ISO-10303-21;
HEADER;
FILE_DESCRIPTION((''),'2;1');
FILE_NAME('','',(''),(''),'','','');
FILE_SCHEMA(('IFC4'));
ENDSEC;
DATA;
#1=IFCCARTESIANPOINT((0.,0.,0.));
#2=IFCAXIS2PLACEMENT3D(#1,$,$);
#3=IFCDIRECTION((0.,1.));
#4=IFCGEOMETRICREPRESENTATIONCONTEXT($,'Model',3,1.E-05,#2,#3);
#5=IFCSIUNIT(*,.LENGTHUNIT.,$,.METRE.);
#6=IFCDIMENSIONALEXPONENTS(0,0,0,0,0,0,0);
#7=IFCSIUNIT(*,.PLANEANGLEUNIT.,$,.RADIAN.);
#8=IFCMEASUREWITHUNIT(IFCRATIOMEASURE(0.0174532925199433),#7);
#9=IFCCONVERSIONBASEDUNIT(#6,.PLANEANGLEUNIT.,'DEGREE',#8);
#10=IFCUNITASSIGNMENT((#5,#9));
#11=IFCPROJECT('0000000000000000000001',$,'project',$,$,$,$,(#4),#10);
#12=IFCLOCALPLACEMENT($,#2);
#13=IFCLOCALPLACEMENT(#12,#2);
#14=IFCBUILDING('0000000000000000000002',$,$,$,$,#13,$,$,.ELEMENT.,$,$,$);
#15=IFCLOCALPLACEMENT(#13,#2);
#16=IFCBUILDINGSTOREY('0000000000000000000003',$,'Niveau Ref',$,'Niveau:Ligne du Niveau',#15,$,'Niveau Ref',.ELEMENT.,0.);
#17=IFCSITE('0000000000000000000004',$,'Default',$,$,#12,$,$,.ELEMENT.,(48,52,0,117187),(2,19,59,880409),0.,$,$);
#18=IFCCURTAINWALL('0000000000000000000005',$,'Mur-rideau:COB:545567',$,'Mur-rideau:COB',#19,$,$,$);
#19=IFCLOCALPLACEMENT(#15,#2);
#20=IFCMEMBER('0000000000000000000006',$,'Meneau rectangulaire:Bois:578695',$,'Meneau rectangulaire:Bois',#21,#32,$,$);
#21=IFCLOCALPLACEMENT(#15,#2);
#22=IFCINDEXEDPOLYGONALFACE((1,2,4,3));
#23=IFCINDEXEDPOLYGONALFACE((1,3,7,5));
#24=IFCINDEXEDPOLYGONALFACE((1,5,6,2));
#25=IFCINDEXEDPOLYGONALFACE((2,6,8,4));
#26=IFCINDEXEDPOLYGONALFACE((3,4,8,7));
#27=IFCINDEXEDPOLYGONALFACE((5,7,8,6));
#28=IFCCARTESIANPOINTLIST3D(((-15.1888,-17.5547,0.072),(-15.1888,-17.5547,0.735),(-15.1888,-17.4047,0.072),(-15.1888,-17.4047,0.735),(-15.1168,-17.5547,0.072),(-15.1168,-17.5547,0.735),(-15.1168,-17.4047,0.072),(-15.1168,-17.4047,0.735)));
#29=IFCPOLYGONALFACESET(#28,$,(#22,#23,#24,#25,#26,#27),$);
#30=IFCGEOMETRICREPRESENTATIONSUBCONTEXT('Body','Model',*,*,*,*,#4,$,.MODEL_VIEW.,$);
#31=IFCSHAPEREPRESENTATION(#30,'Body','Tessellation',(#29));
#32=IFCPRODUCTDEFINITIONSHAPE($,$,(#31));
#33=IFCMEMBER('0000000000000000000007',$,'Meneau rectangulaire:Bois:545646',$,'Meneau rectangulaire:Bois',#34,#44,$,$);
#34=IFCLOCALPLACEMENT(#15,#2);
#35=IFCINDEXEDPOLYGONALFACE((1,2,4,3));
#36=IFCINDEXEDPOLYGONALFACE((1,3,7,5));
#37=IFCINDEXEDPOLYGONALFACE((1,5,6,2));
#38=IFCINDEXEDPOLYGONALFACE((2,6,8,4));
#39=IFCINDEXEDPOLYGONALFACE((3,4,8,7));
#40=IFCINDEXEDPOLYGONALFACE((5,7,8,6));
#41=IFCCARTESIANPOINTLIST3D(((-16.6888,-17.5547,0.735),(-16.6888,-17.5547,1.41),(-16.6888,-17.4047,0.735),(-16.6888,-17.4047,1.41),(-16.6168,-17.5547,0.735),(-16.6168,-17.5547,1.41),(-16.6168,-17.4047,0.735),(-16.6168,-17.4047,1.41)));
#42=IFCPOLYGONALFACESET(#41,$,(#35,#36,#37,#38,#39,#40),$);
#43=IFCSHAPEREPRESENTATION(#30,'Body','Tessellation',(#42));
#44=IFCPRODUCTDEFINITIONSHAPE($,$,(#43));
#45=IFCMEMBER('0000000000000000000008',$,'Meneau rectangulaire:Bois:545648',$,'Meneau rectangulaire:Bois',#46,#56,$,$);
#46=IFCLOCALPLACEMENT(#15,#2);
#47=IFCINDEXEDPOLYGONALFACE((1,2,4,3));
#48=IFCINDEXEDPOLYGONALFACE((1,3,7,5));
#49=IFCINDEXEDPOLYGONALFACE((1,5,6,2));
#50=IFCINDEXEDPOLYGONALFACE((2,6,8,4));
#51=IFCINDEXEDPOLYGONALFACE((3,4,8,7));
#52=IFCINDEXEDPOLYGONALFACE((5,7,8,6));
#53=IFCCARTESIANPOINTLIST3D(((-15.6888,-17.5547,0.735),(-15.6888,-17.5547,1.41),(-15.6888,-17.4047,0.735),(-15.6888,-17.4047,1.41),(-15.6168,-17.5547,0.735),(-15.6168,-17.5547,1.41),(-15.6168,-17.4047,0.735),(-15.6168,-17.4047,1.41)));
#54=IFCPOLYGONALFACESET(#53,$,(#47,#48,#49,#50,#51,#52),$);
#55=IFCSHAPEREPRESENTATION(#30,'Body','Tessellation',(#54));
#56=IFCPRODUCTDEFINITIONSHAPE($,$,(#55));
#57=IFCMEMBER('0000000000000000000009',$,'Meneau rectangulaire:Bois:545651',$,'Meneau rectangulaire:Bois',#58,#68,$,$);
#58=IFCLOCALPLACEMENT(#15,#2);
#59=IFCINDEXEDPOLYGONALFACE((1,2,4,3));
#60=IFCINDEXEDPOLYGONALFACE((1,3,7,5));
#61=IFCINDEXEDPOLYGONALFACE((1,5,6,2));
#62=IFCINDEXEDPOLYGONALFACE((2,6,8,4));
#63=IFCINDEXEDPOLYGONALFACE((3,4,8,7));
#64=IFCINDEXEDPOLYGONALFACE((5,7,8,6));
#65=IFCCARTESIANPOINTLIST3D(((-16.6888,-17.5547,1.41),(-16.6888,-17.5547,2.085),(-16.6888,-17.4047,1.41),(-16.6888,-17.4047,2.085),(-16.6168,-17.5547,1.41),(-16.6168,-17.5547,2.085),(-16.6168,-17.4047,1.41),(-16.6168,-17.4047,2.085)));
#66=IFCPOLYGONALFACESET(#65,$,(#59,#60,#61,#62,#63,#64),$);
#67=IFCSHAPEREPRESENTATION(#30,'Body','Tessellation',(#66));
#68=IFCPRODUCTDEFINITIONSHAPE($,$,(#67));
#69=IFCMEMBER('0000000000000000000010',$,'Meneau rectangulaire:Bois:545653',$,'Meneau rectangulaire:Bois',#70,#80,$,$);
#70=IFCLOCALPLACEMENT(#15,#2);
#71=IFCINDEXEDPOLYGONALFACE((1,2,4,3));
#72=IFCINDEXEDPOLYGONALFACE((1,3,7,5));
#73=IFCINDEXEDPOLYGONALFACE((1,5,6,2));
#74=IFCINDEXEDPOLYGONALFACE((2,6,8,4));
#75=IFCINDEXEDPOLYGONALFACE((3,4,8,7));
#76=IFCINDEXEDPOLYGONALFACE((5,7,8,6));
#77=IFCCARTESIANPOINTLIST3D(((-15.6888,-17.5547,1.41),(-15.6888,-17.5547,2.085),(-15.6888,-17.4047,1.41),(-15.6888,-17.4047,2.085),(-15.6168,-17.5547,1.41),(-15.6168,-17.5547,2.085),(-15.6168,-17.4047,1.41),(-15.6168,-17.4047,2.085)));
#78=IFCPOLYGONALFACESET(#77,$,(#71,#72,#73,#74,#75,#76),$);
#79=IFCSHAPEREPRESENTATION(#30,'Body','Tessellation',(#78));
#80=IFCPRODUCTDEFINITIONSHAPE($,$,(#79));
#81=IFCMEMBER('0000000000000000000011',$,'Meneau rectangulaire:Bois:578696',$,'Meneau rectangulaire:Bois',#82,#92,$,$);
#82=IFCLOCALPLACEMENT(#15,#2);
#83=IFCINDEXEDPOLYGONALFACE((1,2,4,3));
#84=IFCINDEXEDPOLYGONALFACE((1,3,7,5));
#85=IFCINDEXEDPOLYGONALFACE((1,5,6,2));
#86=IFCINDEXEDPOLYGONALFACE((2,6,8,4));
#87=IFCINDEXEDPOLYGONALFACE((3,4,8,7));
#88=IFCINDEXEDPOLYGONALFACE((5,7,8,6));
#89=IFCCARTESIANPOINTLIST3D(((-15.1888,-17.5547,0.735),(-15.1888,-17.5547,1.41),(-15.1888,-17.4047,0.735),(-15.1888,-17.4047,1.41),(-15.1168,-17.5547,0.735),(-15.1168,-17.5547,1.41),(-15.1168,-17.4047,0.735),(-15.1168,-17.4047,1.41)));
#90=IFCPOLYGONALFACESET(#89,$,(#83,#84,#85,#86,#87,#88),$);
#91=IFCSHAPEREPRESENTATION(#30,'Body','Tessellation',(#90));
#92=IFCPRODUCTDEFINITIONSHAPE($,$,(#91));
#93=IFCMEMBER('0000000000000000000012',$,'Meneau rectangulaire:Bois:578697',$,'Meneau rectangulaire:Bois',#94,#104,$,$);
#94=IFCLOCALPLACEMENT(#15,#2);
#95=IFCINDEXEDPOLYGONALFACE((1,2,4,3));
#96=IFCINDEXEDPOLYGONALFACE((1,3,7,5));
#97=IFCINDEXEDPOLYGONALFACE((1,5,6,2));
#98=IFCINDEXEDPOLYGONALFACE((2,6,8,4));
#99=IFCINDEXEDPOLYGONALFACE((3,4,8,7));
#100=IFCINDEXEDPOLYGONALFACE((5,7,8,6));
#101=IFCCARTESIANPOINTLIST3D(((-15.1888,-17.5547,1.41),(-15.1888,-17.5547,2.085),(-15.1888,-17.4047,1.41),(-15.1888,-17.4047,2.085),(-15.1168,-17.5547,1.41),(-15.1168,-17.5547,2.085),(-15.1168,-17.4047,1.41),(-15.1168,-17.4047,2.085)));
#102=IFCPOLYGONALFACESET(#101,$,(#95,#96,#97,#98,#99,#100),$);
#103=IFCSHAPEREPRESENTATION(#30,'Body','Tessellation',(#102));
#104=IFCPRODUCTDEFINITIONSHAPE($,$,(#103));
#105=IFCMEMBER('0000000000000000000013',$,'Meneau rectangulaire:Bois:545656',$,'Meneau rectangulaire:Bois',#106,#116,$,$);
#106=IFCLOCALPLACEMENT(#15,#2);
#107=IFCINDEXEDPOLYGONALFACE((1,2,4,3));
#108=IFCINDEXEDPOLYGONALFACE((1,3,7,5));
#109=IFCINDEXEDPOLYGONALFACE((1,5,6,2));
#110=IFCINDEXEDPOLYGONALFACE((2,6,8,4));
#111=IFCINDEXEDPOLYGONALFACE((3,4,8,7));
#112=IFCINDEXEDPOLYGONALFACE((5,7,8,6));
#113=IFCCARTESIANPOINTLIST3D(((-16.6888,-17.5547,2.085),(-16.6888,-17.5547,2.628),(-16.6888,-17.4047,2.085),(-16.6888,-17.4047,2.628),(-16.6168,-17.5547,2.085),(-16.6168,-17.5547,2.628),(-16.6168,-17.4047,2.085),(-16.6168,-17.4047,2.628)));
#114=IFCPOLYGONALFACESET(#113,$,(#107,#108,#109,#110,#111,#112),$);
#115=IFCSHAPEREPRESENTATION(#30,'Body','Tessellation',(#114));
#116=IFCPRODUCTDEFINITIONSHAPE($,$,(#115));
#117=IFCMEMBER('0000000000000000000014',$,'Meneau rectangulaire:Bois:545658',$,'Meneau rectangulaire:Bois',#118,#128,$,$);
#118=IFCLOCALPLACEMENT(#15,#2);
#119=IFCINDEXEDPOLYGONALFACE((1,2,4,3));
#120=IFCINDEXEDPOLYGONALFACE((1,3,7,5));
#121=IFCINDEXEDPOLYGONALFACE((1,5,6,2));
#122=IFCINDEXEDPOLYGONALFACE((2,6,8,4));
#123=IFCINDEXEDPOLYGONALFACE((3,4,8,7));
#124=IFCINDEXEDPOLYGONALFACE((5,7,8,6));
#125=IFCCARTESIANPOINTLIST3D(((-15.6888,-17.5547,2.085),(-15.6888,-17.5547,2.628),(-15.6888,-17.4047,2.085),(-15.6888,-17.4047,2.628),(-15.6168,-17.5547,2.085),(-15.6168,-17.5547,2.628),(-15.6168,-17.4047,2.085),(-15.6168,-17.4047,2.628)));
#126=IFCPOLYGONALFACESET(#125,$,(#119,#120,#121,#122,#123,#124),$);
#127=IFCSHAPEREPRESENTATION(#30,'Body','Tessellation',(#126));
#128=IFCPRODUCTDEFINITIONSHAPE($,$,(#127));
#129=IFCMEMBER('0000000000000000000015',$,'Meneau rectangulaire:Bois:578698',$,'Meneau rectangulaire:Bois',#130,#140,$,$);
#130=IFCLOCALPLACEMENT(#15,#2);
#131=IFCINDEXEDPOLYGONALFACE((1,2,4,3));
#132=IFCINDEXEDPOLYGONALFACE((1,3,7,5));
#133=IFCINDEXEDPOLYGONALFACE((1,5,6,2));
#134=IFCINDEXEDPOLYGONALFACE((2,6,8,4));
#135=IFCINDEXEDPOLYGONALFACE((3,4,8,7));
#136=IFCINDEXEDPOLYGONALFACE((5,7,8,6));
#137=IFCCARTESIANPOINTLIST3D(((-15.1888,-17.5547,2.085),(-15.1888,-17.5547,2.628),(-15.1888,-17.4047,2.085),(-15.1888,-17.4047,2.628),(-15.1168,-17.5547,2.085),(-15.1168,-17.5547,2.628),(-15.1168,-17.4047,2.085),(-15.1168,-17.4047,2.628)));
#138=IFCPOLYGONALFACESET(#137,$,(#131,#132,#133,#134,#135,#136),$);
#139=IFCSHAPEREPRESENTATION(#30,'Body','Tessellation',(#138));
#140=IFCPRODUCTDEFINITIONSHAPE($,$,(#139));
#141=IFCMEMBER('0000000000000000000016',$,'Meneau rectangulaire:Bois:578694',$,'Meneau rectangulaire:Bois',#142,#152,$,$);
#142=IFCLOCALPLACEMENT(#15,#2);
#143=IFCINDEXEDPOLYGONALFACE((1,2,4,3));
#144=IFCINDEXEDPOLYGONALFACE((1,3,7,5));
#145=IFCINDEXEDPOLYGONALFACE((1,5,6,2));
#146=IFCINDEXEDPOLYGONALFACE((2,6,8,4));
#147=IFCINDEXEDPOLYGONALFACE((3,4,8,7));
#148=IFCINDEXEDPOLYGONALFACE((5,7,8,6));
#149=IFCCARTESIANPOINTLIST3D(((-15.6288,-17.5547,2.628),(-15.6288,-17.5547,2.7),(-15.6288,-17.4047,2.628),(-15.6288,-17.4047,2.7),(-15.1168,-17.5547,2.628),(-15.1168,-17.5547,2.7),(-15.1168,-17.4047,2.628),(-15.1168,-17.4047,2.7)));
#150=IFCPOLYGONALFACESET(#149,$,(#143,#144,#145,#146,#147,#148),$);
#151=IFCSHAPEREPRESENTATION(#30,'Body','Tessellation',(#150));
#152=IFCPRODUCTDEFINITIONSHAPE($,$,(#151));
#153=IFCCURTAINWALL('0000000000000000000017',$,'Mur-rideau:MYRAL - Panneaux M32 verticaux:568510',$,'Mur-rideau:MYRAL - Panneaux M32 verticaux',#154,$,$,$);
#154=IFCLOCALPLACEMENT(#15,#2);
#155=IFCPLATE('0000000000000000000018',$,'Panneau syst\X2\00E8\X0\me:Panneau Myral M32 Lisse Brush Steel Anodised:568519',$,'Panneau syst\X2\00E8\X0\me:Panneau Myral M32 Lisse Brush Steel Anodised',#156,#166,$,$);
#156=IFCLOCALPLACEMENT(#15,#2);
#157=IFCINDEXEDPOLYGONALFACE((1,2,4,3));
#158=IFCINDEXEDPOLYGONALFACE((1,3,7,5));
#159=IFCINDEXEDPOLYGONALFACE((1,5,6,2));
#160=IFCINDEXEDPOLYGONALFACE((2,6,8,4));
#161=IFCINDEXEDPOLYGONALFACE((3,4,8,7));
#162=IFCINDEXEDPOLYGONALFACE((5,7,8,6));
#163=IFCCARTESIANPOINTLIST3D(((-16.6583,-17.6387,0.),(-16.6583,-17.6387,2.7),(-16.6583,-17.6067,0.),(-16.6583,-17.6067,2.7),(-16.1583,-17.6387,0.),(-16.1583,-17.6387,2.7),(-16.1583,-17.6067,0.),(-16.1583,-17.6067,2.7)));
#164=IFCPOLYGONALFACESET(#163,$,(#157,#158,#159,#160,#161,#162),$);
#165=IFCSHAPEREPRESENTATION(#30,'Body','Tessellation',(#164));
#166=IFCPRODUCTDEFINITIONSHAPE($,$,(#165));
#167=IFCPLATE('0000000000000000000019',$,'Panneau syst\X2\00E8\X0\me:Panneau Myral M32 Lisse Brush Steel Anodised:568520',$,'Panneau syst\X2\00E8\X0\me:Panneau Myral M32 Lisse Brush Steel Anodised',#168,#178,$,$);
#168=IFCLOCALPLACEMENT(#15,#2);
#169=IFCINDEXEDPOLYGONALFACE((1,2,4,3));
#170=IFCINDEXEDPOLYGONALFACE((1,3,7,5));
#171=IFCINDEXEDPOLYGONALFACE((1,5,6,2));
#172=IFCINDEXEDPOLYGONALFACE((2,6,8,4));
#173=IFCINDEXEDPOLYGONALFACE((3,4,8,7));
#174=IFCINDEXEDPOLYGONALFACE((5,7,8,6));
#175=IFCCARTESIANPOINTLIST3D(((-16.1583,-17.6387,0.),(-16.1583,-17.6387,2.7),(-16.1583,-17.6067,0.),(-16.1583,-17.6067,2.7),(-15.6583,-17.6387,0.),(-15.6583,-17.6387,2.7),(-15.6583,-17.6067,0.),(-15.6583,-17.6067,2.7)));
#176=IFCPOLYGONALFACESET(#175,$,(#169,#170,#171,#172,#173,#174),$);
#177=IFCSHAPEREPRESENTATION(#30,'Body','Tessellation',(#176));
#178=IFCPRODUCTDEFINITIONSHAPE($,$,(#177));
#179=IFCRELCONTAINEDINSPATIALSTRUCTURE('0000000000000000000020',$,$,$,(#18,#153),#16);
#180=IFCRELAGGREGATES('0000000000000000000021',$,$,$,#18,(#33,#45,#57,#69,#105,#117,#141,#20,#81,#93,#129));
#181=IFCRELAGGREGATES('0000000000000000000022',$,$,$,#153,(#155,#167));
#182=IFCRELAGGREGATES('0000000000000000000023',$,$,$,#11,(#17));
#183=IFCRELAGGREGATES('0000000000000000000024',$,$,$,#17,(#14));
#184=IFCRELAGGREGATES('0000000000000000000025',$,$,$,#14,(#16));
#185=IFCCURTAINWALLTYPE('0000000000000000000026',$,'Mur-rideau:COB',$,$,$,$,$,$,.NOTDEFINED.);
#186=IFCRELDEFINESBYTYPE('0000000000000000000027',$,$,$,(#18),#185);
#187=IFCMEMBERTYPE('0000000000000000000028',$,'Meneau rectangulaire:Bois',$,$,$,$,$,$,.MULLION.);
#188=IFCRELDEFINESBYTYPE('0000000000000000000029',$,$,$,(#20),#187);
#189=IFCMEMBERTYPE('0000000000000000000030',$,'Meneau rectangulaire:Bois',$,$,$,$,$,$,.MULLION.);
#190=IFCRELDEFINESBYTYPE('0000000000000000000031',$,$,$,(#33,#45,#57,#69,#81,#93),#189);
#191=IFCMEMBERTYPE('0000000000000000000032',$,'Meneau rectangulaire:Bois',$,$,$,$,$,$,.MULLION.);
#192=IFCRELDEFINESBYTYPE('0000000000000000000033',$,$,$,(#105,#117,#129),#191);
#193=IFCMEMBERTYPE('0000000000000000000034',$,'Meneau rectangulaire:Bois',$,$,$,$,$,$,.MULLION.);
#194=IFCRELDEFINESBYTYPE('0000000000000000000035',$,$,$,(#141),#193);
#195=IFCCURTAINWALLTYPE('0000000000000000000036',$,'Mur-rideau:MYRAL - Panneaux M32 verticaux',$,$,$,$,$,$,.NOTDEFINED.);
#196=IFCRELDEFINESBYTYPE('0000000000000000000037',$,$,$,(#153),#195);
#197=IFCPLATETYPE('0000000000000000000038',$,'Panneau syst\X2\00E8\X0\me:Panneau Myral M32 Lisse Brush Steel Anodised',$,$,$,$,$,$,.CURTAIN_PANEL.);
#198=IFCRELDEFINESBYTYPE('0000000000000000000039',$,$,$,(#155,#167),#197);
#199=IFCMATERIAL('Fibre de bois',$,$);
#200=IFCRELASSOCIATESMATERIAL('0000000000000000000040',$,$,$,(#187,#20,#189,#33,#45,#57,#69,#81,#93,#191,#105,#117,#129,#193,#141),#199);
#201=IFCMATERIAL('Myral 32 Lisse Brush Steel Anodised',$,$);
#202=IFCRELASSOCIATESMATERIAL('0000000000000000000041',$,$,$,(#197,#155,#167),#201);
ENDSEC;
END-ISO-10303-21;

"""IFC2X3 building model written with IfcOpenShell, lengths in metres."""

from ifc_helpers import new_model, entity, si_unit, converted_unit, direction, frame, origin, origin_2d_with_axis, place, context, subcontext, project, spatial, rectangle, extrude, source, transform, mapped, material, type_object, type_shapes, element, aggregate, save


model = new_model("IFC2X3")

# Units and contexts
model_context = context("Model", 3, precision=1e-05, world=origin(), true_north=direction((0.0, 1.0)))
body_context = subcontext(model_context, "Body", "Model", "MODEL_VIEW")
ifc_project = project(units=[si_unit("LENGTHUNIT", "METRE"), converted_unit("PLANEANGLEUNIT", "DEGREE", entity("IfcRatioMeasure", 0.0174532925199433), si_unit("PLANEANGLEUNIT", "RADIAN"), dimensions=[0, 0, 0, 0, 0, 0, 0])], contexts=[model_context])

# Site, building, storey
site_placement = place(None, origin())
site = spatial("IfcSite", under=ifc_project, at=site_placement, Name="Default", CompositionType="ELEMENT", RefLatitude=(48, 52, 0, 117187), RefLongitude=(2, 19, 59, 880409), RefElevation=0.0)
building_placement = place(site_placement, origin())
building = spatial("IfcBuilding", under=site, at=building_placement, CompositionType="ELEMENT")
storey_placement = place(building_placement, origin())
storey = spatial("IfcBuildingStorey", under=building, at=storey_placement, Name="Niveau Ref", ObjectType="Niveau:Ligne du Niveau", LongName="Niveau Ref", CompositionType="ELEMENT", Elevation=0.0)

# Curtain wall, members
curtain_wall_type_1 = type_object("IfcCurtainWallType", Name="Mur-rideau:COB", PredefinedType="NOTDEFINED")
curtain_wall_1_placement = place(storey_placement, origin())
curtain_wall_1 = element("IfcCurtainWall", 1, at=curtain_wall_1_placement, inside=storey, type_object=curtain_wall_type_1, Name="Mur-rideau:COB:545567", ObjectType="Mur-rideau:COB")
ifc_material_1 = material(Name="Fibre de bois")
member_type_1 = type_object("IfcMemberType", Name="Meneau rectangulaire:Bois", PredefinedType="MULLION", material=ifc_material_1)
shared_shape_1 = source(origin(), body_context, "Body", "SweptSolid", [
    extrude(rectangle(XDim=0.15, YDim=0.072, at=origin_2d_with_axis()), frame((-0.024, 0.0, -0.663), z_axis=(0.0, 0.0, 1.0), x_axis=(0.0, -1.0, 0.0)), (0.0, 0.0, 1.0), 0.663),
])
type_shapes(member_type_1, [shared_shape_1])
member_1_placement = place(storey_placement, frame((-15.1288, -17.4797, 0.072), z_axis=(0.0, 0.0, -1.0), x_axis=(1.0, 0.0, 0.0)))
member_1 = element("IfcMember", 2, at=member_1_placement, type_object=member_type_1, material=ifc_material_1, Name="Meneau rectangulaire:Bois:578695", ObjectType="Meneau rectangulaire:Bois", context=body_context, shape_type="MappedRepresentation", body=[
    mapped(shared_shape_1, transform((0.0, 0.0, 0.0), scale=1.0)),
])
member_type_2 = type_object("IfcMemberType", Name="Meneau rectangulaire:Bois", PredefinedType="MULLION", material=ifc_material_1)
shared_shape_2 = source(origin(), body_context, "Body", "SweptSolid", [
    extrude(rectangle(XDim=0.15, YDim=0.072, at=origin_2d_with_axis()), frame((-0.024, 0.0, -0.675), z_axis=(0.0, 0.0, 1.0), x_axis=(0.0, -1.0, 0.0)), (0.0, 0.0, 1.0), 0.675),
])
type_shapes(member_type_2, [shared_shape_2])
member_2_placement = place(storey_placement, frame((-16.6288, -17.4797, 0.735), z_axis=(0.0, 0.0, -1.0), x_axis=(1.0, 0.0, 0.0)))
member_2 = element("IfcMember", 3, at=member_2_placement, type_object=member_type_2, material=ifc_material_1, Name="Meneau rectangulaire:Bois:545646", ObjectType="Meneau rectangulaire:Bois", context=body_context, shape_type="MappedRepresentation", body=[
    mapped(shared_shape_2, transform((0.0, 0.0, 0.0), scale=1.0)),
])
member_3_placement = place(storey_placement, frame((-15.6288, -17.4797, 0.735), z_axis=(0.0, 0.0, -1.0), x_axis=(1.0, 0.0, 0.0)))
member_3 = element("IfcMember", 4, at=member_3_placement, type_object=member_type_2, material=ifc_material_1, Name="Meneau rectangulaire:Bois:545648", ObjectType="Meneau rectangulaire:Bois", context=body_context, shape_type="MappedRepresentation", body=[
    mapped(shared_shape_2, transform((0.0, 0.0, 0.0), scale=1.0)),
])
member_4_placement = place(storey_placement, frame((-16.6288, -17.4797, 1.41), z_axis=(0.0, 0.0, -1.0), x_axis=(1.0, 0.0, 0.0)))
member_4 = element("IfcMember", 5, at=member_4_placement, type_object=member_type_2, material=ifc_material_1, Name="Meneau rectangulaire:Bois:545651", ObjectType="Meneau rectangulaire:Bois", context=body_context, shape_type="MappedRepresentation", body=[
    mapped(shared_shape_2, transform((0.0, 0.0, 0.0), scale=1.0)),
])
member_5_placement = place(storey_placement, frame((-15.6288, -17.4797, 1.41), z_axis=(0.0, 0.0, -1.0), x_axis=(1.0, 0.0, 0.0)))
member_5 = element("IfcMember", 6, at=member_5_placement, type_object=member_type_2, material=ifc_material_1, Name="Meneau rectangulaire:Bois:545653", ObjectType="Meneau rectangulaire:Bois", context=body_context, shape_type="MappedRepresentation", body=[
    mapped(shared_shape_2, transform((0.0, 0.0, 0.0), scale=1.0)),
])
member_6_placement = place(storey_placement, frame((-15.1288, -17.4797, 0.735), z_axis=(0.0, 0.0, -1.0), x_axis=(1.0, 0.0, 0.0)))
member_6 = element("IfcMember", 7, at=member_6_placement, type_object=member_type_2, material=ifc_material_1, Name="Meneau rectangulaire:Bois:578696", ObjectType="Meneau rectangulaire:Bois", context=body_context, shape_type="MappedRepresentation", body=[
    mapped(shared_shape_2, transform((0.0, 0.0, 0.0), scale=1.0)),
])
member_7_placement = place(storey_placement, frame((-15.1288, -17.4797, 1.41), z_axis=(0.0, 0.0, -1.0), x_axis=(1.0, 0.0, 0.0)))
member_7 = element("IfcMember", 8, at=member_7_placement, type_object=member_type_2, material=ifc_material_1, Name="Meneau rectangulaire:Bois:578697", ObjectType="Meneau rectangulaire:Bois", context=body_context, shape_type="MappedRepresentation", body=[
    mapped(shared_shape_2, transform((0.0, 0.0, 0.0), scale=1.0)),
])
member_type_3 = type_object("IfcMemberType", Name="Meneau rectangulaire:Bois", PredefinedType="MULLION", material=ifc_material_1)
shared_shape_3 = source(origin(), body_context, "Body", "SweptSolid", [
    extrude(rectangle(XDim=0.15, YDim=0.072, at=origin_2d_with_axis()), frame((-0.024, 0.0, -0.543), z_axis=(0.0, 0.0, 1.0), x_axis=(0.0, -1.0, 0.0)), (0.0, 0.0, 1.0), 0.543),
])
type_shapes(member_type_3, [shared_shape_3])
member_8_placement = place(storey_placement, frame((-16.6288, -17.4797, 2.085), z_axis=(0.0, 0.0, -1.0), x_axis=(1.0, 0.0, 0.0)))
member_8 = element("IfcMember", 9, at=member_8_placement, type_object=member_type_3, material=ifc_material_1, Name="Meneau rectangulaire:Bois:545656", ObjectType="Meneau rectangulaire:Bois", context=body_context, shape_type="MappedRepresentation", body=[
    mapped(shared_shape_3, transform((0.0, 0.0, 0.0), scale=1.0)),
])
member_9_placement = place(storey_placement, frame((-15.6288, -17.4797, 2.085), z_axis=(0.0, 0.0, -1.0), x_axis=(1.0, 0.0, 0.0)))
member_9 = element("IfcMember", 10, at=member_9_placement, type_object=member_type_3, material=ifc_material_1, Name="Meneau rectangulaire:Bois:545658", ObjectType="Meneau rectangulaire:Bois", context=body_context, shape_type="MappedRepresentation", body=[
    mapped(shared_shape_3, transform((0.0, 0.0, 0.0), scale=1.0)),
])
member_10_placement = place(storey_placement, frame((-15.1288, -17.4797, 2.085), z_axis=(0.0, 0.0, -1.0), x_axis=(1.0, 0.0, 0.0)))
member_10 = element("IfcMember", 11, at=member_10_placement, type_object=member_type_3, material=ifc_material_1, Name="Meneau rectangulaire:Bois:578698", ObjectType="Meneau rectangulaire:Bois", context=body_context, shape_type="MappedRepresentation", body=[
    mapped(shared_shape_3, transform((0.0, 0.0, 0.0), scale=1.0)),
])
member_type_4 = type_object("IfcMemberType", Name="Meneau rectangulaire:Bois", PredefinedType="MULLION", material=ifc_material_1)
shared_shape_4 = source(origin(), body_context, "Body", "SweptSolid", [
    extrude(rectangle(XDim=0.15, YDim=0.072, at=origin_2d_with_axis()), frame((-0.036, 0.0, -0.512), z_axis=(0.0, 0.0, 1.0), x_axis=(0.0, -1.0, 0.0)), (0.0, 0.0, 1.0), 0.512),
])
type_shapes(member_type_4, [shared_shape_4])
member_11_placement = place(storey_placement, frame((-15.1168, -17.4797, 2.7), z_axis=(1.0, 0.0, 0.0), x_axis=(0.0, 0.0, 1.0)))
member_11 = element("IfcMember", 12, at=member_11_placement, type_object=member_type_4, material=ifc_material_1, Name="Meneau rectangulaire:Bois:578694", ObjectType="Meneau rectangulaire:Bois", context=body_context, shape_type="MappedRepresentation", body=[
    mapped(shared_shape_4, transform((0.0, 0.0, 0.0), scale=1.0)),
])
aggregate(curtain_wall_1, [member_2, member_3, member_4, member_5, member_8, member_9, member_11, member_1, member_6, member_7, member_10])

# Curtain wall, plates
curtain_wall_type_2 = type_object("IfcCurtainWallType", Name="Mur-rideau:MYRAL - Panneaux M32 verticaux", PredefinedType="NOTDEFINED")
curtain_wall_2_placement = place(storey_placement, origin())
curtain_wall_2 = element("IfcCurtainWall", 13, at=curtain_wall_2_placement, inside=storey, type_object=curtain_wall_type_2, Name="Mur-rideau:MYRAL - Panneaux M32 verticaux:568510", ObjectType="Mur-rideau:MYRAL - Panneaux M32 verticaux")
ifc_material_2 = material(Name="Myral 32 Lisse Brush Steel Anodised")
plate_type = type_object("IfcPlateType", Name="Panneau système:Panneau Myral M32 Lisse Brush Steel Anodised", PredefinedType="CURTAIN_PANEL", material=ifc_material_2)
shared_shape_5 = source(origin(), body_context, "Body", "SweptSolid", [
    extrude(rectangle(XDim=0.032, YDim=0.5, at=origin_2d_with_axis()), frame((0.0, -0.016, 0.0), z_axis=(0.0, 0.0, 1.0), x_axis=(0.0, 1.0, 0.0)), (0.0, 0.0, 1.0), 2.7),
])
type_shapes(plate_type, [shared_shape_5])
plate_1_placement = place(curtain_wall_2_placement, frame((-16.4083, -17.6067, 0.0)))
plate_1 = element("IfcPlate", 14, at=plate_1_placement, type_object=plate_type, material=ifc_material_2, Name="Panneau système:Panneau Myral M32 Lisse Brush Steel Anodised:568519", ObjectType="Panneau système:Panneau Myral M32 Lisse Brush Steel Anodised", context=body_context, shape_type="MappedRepresentation", body=[
    mapped(shared_shape_5, transform((0.0, 0.0, 0.0), scale=1.0)),
])
plate_2_placement = place(curtain_wall_2_placement, frame((-15.9083, -17.6067, 0.0)))
plate_2 = element("IfcPlate", 15, at=plate_2_placement, type_object=plate_type, material=ifc_material_2, Name="Panneau système:Panneau Myral M32 Lisse Brush Steel Anodised:568520", ObjectType="Panneau système:Panneau Myral M32 Lisse Brush Steel Anodised", context=body_context, shape_type="MappedRepresentation", body=[
    mapped(shared_shape_5, transform((0.0, 0.0, 0.0), scale=1.0)),
])
aggregate(curtain_wall_2, [plate_1, plate_2])

save(model, "model.ifc")
